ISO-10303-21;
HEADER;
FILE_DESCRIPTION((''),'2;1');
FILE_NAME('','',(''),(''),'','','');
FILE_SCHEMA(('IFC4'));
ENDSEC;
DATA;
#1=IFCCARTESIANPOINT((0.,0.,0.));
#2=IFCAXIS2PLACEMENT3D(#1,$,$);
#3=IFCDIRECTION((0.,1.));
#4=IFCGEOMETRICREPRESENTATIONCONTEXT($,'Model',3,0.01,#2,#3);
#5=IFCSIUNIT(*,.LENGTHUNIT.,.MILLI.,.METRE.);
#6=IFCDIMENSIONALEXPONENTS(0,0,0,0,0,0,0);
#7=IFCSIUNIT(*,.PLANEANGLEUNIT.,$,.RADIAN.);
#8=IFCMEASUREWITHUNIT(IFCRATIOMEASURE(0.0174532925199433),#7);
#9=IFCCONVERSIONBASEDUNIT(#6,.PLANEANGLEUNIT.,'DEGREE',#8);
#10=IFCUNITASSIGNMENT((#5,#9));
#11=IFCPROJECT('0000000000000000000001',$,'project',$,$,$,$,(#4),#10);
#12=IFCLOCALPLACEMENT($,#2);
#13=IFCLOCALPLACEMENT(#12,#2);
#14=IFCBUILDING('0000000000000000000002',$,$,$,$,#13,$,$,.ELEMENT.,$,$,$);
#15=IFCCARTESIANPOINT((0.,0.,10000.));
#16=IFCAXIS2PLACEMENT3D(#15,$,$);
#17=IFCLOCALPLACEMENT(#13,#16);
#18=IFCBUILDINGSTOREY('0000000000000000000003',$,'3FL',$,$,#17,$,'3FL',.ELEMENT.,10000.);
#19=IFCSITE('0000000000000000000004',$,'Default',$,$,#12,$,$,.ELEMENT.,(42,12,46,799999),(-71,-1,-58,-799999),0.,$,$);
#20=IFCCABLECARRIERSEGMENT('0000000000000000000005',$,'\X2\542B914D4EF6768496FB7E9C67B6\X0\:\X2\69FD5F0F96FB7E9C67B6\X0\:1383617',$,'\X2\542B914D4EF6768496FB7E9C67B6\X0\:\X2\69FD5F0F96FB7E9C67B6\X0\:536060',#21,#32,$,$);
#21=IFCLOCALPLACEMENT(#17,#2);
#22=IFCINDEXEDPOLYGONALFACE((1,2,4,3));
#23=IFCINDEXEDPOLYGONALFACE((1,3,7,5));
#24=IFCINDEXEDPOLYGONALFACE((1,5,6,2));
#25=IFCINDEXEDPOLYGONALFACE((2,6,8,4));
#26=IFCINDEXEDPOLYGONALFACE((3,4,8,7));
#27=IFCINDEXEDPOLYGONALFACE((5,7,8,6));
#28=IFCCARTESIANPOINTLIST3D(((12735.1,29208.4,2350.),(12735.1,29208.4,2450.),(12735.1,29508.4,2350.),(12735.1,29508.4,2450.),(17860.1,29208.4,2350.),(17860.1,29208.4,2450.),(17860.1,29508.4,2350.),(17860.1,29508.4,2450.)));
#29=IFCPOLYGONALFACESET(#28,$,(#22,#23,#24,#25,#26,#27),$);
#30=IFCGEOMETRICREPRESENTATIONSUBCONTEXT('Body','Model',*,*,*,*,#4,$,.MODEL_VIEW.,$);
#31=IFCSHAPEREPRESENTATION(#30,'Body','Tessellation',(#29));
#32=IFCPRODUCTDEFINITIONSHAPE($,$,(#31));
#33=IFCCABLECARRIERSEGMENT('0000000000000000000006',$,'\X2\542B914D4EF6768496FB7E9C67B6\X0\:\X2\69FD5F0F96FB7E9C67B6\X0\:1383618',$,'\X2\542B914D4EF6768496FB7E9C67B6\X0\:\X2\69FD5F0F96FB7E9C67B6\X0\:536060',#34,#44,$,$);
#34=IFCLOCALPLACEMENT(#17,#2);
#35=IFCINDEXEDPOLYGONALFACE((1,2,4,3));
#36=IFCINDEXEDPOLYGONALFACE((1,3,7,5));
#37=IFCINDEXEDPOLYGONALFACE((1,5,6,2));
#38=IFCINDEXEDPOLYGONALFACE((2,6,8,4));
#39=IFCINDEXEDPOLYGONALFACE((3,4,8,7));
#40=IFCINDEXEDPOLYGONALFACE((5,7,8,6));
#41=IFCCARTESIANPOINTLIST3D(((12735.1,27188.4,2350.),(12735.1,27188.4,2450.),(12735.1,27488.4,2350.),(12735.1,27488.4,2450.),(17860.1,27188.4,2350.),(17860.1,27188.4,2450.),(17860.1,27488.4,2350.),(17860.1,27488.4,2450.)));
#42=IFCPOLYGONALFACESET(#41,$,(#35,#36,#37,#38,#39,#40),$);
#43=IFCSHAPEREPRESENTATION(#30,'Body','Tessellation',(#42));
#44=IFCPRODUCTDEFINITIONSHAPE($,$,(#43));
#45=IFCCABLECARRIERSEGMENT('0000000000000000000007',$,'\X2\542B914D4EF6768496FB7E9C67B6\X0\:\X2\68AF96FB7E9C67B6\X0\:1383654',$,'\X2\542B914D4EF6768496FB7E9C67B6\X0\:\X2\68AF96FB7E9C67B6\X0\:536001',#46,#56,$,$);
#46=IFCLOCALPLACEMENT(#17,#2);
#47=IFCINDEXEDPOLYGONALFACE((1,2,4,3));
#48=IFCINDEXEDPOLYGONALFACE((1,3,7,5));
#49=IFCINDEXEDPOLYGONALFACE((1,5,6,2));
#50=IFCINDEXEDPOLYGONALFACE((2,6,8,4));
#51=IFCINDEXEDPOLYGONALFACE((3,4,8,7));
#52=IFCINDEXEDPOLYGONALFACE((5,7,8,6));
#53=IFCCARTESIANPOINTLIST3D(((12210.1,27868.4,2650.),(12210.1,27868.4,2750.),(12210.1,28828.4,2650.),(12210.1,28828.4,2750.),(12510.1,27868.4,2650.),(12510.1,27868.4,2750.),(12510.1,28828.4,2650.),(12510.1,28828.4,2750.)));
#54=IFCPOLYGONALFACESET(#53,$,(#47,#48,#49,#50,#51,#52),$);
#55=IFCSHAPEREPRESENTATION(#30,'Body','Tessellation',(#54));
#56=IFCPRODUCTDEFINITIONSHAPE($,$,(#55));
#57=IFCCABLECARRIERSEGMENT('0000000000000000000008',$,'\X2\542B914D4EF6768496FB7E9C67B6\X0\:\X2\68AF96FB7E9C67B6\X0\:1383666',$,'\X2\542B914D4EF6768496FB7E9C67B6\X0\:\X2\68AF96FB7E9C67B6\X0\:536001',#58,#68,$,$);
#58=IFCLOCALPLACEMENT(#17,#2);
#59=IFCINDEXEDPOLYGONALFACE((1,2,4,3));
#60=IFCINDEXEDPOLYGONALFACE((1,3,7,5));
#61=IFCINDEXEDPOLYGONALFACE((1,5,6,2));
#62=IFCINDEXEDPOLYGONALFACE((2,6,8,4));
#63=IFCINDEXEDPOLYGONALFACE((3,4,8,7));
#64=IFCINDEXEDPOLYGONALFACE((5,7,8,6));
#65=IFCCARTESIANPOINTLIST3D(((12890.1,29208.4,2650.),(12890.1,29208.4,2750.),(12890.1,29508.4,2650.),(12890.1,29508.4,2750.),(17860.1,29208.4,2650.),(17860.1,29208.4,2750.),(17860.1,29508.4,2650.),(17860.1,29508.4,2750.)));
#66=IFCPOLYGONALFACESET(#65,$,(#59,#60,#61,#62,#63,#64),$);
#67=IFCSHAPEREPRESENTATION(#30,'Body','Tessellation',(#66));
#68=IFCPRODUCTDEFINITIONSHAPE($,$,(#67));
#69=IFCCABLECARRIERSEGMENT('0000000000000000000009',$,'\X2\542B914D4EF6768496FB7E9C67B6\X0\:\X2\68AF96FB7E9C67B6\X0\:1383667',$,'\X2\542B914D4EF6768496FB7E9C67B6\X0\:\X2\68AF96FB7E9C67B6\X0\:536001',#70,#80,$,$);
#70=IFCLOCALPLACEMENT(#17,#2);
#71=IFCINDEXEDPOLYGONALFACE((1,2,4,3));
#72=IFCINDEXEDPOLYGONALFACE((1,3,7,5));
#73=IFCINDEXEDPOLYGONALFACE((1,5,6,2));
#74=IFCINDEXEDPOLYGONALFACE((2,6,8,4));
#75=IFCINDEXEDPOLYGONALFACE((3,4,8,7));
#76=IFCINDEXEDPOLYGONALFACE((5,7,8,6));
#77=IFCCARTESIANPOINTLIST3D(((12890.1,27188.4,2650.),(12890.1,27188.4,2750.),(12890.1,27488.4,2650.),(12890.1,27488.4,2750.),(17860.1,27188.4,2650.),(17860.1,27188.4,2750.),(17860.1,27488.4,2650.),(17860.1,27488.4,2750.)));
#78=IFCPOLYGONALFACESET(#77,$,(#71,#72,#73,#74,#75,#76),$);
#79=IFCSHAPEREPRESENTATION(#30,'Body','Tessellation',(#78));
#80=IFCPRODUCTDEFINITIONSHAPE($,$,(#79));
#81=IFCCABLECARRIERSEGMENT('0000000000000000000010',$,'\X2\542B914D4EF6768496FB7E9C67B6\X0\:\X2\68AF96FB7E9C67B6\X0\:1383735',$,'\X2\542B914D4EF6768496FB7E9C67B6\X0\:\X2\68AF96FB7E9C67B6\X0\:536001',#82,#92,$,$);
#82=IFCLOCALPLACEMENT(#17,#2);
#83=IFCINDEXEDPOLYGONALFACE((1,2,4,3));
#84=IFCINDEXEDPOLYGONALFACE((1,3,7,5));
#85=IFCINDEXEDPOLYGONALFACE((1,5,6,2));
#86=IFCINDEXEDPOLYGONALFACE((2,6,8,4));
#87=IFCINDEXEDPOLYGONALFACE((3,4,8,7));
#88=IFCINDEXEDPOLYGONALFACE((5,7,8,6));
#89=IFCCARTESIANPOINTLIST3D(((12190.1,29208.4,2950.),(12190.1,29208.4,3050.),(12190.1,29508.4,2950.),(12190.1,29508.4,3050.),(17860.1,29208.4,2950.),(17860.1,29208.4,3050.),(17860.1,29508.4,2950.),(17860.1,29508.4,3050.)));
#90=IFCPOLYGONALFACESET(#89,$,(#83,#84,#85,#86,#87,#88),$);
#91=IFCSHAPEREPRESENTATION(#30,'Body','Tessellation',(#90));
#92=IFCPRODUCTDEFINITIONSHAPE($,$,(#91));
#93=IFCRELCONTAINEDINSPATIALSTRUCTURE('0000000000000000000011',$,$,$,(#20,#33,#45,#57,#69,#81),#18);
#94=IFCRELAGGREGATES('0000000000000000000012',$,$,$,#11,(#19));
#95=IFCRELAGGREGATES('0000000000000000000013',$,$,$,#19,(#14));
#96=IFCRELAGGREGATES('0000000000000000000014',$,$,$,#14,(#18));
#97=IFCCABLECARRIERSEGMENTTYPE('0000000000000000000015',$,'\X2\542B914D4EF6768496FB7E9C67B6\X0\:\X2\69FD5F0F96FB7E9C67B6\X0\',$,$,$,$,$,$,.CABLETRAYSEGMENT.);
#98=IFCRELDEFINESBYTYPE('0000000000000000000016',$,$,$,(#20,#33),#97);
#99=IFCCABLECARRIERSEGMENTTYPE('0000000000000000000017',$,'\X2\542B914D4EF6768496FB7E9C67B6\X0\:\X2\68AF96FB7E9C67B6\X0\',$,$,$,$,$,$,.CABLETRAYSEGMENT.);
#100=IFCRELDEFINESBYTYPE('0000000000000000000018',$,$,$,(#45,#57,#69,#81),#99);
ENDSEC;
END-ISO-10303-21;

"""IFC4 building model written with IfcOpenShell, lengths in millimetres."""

from ifc_helpers import new_model, entity, si_unit, converted_unit, direction, frame, frame_2d, origin, origin_2d_with_axis, place, context, subcontext, project, spatial, rectangle, extrude, type_object, element, save


model = new_model("IFC4")

# Units and contexts
model_context = context("Model", 3, precision=0.01, world=origin(), true_north=direction((0.0, 1.0)))
body_context = subcontext(model_context, "Body", "Model", "MODEL_VIEW")
ifc_project = project(units=[si_unit("LENGTHUNIT", "METRE", prefix="MILLI"), converted_unit("PLANEANGLEUNIT", "DEGREE", entity("IfcRatioMeasure", 0.0174532925199433), si_unit("PLANEANGLEUNIT", "RADIAN"), dimensions=[0, 0, 0, 0, 0, 0, 0])], contexts=[model_context])

# Site, building, storey
site_placement = place(None, origin())
site = spatial("IfcSite", under=ifc_project, at=site_placement, Name="Default", CompositionType="ELEMENT", RefLatitude=(42, 12, 46, 799999), RefLongitude=(-71, -1, -58, -799999), RefElevation=0.0)
building_placement = place(site_placement, origin())
building = spatial("IfcBuilding", under=site, at=building_placement, CompositionType="ELEMENT")
storey_placement = place(building_placement, frame((0.0, 0.0, 10000.0)))
storey = spatial("IfcBuildingStorey", under=building, at=storey_placement, Name="3FL", LongName="3FL", CompositionType="ELEMENT", Elevation=10000.0)

# Cable carrier segments
cable_carrier_segment_type_1 = type_object("IfcCableCarrierSegmentType", Name="含配件的電纜架:槽式電纜架", PredefinedType="CABLETRAYSEGMENT")
cable_carrier_segment_1_placement = place(storey_placement, frame((12735.1, 29208.4, 2350.0)))
element("IfcCableCarrierSegment", 1, at=cable_carrier_segment_1_placement, inside=storey, type_object=cable_carrier_segment_type_1, Name="含配件的電纜架:槽式電纜架:1383617", ObjectType="含配件的電纜架:槽式電纜架:536060", context=body_context, shape_type="SweptSolid", body=[
    extrude(rectangle(XDim=5125.0, YDim=300.0, at=frame_2d((0.0, 0.0), x_axis=(1.0, 0.0))), frame((2562.5, 150.0, 0.0), z_axis=(0.0, 0.0, 1.0), x_axis=(-1.0, 0.0, 0.0)), (0.0, 0.0, 1.0), 100.0),
])
cable_carrier_segment_2_placement = place(storey_placement, frame((12735.1, 27188.4, 2350.0)))
element("IfcCableCarrierSegment", 2, at=cable_carrier_segment_2_placement, inside=storey, type_object=cable_carrier_segment_type_1, Name="含配件的電纜架:槽式電纜架:1383618", ObjectType="含配件的電纜架:槽式電纜架:536060", context=body_context, shape_type="SweptSolid", body=[
    extrude(rectangle(XDim=5125.0, YDim=300.0, at=origin_2d_with_axis()), frame((2562.5, 150.0, 0.0), z_axis=(0.0, 0.0, 1.0), x_axis=(-1.0, 0.0, 0.0)), (0.0, 0.0, 1.0), 100.0),
])
cable_carrier_segment_type_2 = type_object("IfcCableCarrierSegmentType", Name="含配件的電纜架:梯電纜架", PredefinedType="CABLETRAYSEGMENT")
cable_carrier_segment_3_placement = place(storey_placement, frame((12210.1, 27868.4, 2650.0)))
element("IfcCableCarrierSegment", 3, at=cable_carrier_segment_3_placement, inside=storey, type_object=cable_carrier_segment_type_2, Name="含配件的電纜架:梯電纜架:1383654", ObjectType="含配件的電纜架:梯電纜架:536001", context=body_context, shape_type="SweptSolid", body=[
    extrude(rectangle(XDim=960.0, YDim=300.0, at=frame_2d((0.0, 0.0), x_axis=(1.0, 0.0))), frame((150.0, 480.0, 0.0), z_axis=(0.0, 0.0, 1.0), x_axis=(0.0, -1.0, 0.0)), (0.0, 0.0, 1.0), 100.0),
])
cable_carrier_segment_4_placement = place(storey_placement, frame((12890.1, 29208.4, 2650.0)))
element("IfcCableCarrierSegment", 4, at=cable_carrier_segment_4_placement, inside=storey, type_object=cable_carrier_segment_type_2, Name="含配件的電纜架:梯電纜架:1383666", ObjectType="含配件的電纜架:梯電纜架:536001", context=body_context, shape_type="SweptSolid", body=[
    extrude(rectangle(XDim=4970.0, YDim=300.0, at=frame_2d((0.0, 0.0), x_axis=(1.0, 0.0))), frame((2485.0, 150.0, 0.0), z_axis=(0.0, 0.0, 1.0), x_axis=(-1.0, 0.0, 0.0)), (0.0, 0.0, 1.0), 100.0),
])
cable_carrier_segment_5_placement = place(storey_placement, frame((12890.1, 27188.4, 2650.0)))
element("IfcCableCarrierSegment", 5, at=cable_carrier_segment_5_placement, inside=storey, type_object=cable_carrier_segment_type_2, Name="含配件的電纜架:梯電纜架:1383667", ObjectType="含配件的電纜架:梯電纜架:536001", context=body_context, shape_type="SweptSolid", body=[
    extrude(rectangle(XDim=4970.0, YDim=300.0, at=origin_2d_with_axis()), frame((2485.0, 150.0, 0.0), z_axis=(0.0, 0.0, 1.0), x_axis=(-1.0, 0.0, 0.0)), (0.0, 0.0, 1.0), 100.0),
])
cable_carrier_segment_6_placement = place(storey_placement, frame((12190.1, 29208.4, 2950.0)))
element("IfcCableCarrierSegment", 6, at=cable_carrier_segment_6_placement, inside=storey, type_object=cable_carrier_segment_type_2, Name="含配件的電纜架:梯電纜架:1383735", ObjectType="含配件的電纜架:梯電纜架:536001", context=body_context, shape_type="SweptSolid", body=[
    extrude(rectangle(XDim=5670.0, YDim=300.0, at=frame_2d((0.0, 0.0), x_axis=(1.0, 0.0))), frame((2835.0, 150.0, 0.0), z_axis=(0.0, 0.0, 1.0), x_axis=(-1.0, 0.0, 0.0)), (0.0, 0.0, 1.0), 100.0),
])

save(model, "model.ifc")
